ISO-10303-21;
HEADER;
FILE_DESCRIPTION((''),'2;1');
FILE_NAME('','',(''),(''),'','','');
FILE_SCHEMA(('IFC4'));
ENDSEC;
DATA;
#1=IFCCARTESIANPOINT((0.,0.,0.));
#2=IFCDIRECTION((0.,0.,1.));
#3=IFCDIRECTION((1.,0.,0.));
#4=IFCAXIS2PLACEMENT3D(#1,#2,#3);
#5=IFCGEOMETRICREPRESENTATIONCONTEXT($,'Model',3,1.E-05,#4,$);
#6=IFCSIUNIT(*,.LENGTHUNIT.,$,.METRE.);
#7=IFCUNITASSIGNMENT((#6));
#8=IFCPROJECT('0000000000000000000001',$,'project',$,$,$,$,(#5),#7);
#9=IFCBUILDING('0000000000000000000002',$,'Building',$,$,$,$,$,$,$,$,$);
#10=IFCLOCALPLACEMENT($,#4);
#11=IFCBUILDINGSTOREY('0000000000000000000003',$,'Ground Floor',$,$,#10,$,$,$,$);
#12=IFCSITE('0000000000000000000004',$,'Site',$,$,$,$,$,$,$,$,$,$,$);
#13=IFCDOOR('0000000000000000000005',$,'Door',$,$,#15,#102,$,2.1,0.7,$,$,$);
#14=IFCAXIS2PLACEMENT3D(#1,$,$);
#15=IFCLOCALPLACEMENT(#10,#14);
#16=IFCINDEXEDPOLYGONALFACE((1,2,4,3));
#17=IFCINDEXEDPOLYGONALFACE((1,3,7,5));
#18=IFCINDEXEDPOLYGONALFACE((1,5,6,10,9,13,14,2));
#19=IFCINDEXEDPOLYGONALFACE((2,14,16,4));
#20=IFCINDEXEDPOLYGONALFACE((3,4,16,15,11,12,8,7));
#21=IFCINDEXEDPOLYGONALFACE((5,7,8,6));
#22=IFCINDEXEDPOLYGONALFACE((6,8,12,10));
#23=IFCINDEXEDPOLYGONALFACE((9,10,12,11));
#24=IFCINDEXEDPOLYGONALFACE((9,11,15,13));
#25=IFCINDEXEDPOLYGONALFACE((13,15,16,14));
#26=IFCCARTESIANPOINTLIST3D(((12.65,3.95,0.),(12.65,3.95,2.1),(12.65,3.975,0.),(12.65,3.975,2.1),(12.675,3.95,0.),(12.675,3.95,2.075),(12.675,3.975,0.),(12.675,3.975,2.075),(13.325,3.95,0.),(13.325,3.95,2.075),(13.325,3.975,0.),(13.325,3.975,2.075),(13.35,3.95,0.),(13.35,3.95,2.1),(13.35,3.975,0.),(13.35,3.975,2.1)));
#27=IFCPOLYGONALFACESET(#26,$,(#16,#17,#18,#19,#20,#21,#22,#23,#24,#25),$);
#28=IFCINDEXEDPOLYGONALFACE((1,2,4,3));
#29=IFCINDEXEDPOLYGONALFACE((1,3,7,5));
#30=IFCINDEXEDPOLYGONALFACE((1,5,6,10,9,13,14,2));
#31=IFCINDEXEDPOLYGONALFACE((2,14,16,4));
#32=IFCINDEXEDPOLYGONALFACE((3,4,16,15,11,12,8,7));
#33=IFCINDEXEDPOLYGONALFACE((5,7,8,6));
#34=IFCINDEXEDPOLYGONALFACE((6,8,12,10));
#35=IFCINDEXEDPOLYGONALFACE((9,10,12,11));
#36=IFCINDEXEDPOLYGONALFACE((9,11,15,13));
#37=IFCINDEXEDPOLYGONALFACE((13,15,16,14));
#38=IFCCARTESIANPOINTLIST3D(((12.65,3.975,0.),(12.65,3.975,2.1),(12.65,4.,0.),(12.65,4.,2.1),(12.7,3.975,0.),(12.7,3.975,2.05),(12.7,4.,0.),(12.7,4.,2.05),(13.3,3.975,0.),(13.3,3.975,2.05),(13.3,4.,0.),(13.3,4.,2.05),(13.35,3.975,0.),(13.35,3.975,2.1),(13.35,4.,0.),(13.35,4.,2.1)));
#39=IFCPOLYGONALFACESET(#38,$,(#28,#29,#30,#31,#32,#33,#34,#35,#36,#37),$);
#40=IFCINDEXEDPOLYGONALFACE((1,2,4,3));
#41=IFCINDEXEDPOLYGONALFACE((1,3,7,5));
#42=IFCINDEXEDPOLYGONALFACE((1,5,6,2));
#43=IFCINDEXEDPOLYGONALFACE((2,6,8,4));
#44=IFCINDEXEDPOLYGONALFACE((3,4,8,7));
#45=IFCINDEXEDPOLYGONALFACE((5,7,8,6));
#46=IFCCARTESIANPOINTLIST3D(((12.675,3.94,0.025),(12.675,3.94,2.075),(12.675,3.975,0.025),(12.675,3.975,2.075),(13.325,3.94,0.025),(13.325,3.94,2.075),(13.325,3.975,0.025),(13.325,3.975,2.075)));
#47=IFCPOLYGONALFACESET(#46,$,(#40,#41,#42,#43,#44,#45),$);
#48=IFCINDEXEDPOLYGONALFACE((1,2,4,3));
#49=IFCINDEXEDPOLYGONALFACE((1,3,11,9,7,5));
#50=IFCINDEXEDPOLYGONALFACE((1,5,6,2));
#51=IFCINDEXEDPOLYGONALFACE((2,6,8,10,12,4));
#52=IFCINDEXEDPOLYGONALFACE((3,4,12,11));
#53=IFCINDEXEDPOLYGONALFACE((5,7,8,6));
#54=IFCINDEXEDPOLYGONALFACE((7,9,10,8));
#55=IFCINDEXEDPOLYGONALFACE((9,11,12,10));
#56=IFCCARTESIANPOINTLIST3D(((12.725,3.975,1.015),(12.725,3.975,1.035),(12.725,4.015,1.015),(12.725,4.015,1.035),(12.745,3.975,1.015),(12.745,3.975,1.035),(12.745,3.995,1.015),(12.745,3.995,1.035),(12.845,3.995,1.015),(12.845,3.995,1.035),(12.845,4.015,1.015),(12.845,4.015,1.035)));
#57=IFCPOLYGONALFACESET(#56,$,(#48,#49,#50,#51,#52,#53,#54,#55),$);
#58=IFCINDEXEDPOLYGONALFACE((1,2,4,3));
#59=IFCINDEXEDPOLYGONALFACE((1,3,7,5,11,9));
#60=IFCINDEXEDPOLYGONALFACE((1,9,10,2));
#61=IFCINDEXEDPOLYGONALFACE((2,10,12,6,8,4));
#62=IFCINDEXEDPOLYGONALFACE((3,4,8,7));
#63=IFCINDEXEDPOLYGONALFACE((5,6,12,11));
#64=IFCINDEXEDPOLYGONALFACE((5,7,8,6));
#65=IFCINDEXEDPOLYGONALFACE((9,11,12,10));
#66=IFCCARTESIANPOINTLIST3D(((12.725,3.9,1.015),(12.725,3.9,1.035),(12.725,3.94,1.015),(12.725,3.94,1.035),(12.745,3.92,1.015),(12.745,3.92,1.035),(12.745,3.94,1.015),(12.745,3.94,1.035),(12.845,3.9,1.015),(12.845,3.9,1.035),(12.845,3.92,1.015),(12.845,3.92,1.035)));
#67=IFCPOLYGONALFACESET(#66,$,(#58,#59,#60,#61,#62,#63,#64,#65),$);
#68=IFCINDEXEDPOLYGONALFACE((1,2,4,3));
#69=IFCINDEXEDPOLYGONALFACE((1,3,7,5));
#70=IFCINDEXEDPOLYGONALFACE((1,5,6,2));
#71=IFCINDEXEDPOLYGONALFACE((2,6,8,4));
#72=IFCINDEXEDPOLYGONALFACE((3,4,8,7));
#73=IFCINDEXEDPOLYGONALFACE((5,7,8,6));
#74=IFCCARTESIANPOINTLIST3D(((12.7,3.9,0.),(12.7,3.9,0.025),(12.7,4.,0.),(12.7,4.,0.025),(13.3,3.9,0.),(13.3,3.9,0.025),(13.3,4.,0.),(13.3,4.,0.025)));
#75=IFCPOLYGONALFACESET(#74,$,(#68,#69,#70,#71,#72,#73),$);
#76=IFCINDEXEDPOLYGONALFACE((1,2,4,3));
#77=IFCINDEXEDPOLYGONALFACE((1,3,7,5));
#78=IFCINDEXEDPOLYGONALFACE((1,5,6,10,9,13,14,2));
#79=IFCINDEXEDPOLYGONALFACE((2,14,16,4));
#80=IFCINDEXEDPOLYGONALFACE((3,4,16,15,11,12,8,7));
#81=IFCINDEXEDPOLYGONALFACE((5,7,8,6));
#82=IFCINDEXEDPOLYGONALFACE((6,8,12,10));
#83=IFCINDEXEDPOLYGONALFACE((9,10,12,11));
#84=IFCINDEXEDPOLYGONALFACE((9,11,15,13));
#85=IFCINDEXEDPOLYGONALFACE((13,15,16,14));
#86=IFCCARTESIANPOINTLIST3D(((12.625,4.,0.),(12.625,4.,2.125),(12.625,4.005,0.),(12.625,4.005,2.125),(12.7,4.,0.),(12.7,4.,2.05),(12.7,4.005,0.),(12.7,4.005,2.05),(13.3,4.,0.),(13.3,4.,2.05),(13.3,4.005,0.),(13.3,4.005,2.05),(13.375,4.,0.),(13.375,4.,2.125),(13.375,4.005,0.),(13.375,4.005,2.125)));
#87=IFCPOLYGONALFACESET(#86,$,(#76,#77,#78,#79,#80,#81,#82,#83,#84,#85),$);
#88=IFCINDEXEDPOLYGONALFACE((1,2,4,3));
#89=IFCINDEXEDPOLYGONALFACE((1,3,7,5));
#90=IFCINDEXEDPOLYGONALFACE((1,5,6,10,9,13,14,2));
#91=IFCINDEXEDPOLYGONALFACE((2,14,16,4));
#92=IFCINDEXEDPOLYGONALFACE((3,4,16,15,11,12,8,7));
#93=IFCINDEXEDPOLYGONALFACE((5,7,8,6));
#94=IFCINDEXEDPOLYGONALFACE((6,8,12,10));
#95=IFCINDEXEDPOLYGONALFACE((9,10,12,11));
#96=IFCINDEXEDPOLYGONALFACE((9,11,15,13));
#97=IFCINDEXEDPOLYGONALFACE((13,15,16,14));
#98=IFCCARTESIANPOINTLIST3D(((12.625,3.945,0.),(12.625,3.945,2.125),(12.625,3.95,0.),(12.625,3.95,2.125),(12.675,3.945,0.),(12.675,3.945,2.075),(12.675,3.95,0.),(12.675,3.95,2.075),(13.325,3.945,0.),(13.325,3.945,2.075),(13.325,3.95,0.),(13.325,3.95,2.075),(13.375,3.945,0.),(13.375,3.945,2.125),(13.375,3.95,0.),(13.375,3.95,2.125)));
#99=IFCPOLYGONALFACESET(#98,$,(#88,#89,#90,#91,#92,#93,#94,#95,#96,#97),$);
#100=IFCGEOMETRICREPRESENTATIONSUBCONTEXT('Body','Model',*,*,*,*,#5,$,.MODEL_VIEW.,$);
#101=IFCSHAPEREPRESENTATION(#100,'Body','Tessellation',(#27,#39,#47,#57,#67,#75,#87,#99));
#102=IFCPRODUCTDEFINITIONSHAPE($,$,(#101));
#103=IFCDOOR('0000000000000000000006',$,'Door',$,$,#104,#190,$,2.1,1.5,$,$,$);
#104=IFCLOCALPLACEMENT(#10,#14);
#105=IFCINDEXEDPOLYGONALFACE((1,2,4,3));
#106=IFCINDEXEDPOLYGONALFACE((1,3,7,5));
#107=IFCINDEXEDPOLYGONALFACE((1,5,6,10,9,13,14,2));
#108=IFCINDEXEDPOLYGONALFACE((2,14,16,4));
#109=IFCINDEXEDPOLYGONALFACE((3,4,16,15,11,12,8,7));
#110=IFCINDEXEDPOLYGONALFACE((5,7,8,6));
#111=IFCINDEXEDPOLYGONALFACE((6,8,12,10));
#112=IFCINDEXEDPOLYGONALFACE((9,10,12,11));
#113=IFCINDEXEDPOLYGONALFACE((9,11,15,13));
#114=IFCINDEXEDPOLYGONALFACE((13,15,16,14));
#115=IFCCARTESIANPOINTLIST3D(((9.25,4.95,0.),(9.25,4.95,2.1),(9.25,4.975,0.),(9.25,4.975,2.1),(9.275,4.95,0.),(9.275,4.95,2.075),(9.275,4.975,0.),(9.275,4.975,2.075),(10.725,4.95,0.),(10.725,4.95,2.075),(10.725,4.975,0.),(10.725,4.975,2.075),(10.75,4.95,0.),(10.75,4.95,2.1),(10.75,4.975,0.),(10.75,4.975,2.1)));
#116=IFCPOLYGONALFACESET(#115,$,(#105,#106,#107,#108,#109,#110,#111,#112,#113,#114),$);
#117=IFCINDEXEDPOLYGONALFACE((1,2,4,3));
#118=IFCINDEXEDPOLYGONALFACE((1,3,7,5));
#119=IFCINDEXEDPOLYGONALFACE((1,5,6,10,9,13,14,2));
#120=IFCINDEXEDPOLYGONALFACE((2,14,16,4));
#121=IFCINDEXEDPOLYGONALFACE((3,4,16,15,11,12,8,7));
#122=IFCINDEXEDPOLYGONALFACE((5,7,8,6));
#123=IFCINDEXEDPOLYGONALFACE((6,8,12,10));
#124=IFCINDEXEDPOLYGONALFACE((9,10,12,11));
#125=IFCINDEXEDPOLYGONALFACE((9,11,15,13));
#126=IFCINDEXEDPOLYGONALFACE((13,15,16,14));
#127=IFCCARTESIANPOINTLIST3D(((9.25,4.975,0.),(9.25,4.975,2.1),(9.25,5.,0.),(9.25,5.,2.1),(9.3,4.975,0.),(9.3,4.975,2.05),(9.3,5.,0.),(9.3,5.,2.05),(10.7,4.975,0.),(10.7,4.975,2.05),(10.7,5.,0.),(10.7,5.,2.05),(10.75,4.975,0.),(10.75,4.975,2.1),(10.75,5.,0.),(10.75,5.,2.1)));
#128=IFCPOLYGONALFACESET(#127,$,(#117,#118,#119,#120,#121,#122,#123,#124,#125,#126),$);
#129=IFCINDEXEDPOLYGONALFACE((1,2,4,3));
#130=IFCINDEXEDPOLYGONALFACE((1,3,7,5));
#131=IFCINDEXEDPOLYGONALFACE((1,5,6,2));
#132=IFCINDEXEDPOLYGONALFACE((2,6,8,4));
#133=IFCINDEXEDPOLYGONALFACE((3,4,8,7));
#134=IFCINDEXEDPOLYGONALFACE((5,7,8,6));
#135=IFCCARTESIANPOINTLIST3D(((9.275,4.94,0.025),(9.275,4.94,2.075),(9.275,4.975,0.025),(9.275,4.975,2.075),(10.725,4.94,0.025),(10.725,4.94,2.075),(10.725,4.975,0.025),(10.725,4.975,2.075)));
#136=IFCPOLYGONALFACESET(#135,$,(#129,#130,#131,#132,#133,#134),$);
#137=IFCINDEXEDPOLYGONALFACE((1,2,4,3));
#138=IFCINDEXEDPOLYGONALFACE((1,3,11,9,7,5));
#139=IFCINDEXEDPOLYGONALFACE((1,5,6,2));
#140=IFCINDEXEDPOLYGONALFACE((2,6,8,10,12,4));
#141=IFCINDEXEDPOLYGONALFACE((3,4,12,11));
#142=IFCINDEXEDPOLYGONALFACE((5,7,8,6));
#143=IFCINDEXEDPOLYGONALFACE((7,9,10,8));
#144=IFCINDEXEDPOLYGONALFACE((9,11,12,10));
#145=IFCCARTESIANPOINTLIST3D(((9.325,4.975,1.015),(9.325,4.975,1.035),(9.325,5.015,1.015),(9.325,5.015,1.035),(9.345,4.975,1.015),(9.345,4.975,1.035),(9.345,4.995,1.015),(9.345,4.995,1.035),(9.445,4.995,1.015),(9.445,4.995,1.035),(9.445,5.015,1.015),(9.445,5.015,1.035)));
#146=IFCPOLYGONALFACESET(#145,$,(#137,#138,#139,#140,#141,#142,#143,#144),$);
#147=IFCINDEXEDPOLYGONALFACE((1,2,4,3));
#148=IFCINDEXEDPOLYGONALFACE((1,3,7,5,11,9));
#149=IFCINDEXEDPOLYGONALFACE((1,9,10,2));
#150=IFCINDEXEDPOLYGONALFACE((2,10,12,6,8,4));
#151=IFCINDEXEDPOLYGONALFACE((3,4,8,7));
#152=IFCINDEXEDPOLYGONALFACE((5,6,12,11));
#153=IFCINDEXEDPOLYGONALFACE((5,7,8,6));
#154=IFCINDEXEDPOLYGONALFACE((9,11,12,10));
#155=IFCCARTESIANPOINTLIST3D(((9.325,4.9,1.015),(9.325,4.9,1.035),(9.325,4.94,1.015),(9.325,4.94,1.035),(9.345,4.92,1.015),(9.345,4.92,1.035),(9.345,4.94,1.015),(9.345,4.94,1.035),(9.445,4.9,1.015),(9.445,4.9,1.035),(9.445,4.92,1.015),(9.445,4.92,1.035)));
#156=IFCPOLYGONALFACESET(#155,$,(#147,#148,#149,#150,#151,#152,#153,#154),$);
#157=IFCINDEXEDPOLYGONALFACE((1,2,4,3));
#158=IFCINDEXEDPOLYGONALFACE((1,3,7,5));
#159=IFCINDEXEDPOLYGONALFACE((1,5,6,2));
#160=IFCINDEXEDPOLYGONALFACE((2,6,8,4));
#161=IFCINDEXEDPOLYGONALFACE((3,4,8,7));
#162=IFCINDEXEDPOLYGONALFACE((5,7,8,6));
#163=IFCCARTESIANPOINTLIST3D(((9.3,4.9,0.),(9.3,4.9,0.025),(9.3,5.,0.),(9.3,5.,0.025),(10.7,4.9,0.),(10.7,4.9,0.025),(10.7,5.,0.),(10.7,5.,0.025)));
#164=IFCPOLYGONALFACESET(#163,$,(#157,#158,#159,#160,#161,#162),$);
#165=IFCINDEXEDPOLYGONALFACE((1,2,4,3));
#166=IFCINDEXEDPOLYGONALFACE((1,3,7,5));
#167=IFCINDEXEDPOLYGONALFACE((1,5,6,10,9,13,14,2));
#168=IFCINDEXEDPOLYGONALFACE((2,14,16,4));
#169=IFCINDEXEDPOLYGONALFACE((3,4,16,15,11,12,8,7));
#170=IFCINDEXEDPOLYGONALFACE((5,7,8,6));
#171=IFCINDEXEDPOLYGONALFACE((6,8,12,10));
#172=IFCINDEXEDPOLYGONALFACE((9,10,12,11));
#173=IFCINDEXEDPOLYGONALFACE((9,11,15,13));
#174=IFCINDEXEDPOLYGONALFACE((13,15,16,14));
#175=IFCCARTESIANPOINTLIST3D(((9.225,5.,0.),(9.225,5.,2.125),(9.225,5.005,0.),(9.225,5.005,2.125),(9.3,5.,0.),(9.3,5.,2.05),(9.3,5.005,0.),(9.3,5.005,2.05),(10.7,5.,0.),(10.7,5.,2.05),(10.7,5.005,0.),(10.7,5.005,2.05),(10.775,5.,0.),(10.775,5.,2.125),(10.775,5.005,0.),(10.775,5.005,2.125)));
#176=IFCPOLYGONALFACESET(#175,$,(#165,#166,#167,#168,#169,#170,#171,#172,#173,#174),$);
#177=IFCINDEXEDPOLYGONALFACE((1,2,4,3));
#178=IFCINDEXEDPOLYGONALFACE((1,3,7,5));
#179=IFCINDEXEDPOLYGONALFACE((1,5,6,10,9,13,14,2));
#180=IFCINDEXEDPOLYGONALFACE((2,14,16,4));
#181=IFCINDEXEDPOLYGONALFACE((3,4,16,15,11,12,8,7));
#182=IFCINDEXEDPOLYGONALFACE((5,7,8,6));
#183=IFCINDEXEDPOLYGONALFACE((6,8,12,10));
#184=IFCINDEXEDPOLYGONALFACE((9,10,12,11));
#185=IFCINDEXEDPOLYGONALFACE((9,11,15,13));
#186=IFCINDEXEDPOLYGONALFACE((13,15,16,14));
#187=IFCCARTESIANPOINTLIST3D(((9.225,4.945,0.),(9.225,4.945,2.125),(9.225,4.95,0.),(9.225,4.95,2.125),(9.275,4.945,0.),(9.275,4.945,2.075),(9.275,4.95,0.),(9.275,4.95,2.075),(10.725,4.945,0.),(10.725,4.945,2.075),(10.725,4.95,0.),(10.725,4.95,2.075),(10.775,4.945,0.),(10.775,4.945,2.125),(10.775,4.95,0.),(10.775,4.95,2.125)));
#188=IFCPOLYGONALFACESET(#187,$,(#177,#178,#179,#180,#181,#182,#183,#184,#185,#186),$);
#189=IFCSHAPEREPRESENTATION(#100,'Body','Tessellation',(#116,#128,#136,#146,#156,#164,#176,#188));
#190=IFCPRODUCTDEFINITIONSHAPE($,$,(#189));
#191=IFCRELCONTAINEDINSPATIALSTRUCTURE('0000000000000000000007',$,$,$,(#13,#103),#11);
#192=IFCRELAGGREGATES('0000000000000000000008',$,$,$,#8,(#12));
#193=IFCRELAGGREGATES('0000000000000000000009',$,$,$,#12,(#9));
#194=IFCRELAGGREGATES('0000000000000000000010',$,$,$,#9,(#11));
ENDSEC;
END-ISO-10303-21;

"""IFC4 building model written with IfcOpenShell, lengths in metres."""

from ifc_helpers import new_model, si_unit, frame, origin_with_axes, place, context, subcontext, project, spatial, line, indexed_curve, outline, extrude, element, save


model = new_model("IFC4")

# Units and contexts
model_context = context("Model", 3, precision=1e-05, world=origin_with_axes())
body_context = subcontext(model_context, "Body", "Model", "MODEL_VIEW")
ifc_project = project(units=[si_unit("LENGTHUNIT", "METRE")], contexts=[model_context])

# Site, building, storey
site = spatial("IfcSite", under=ifc_project, Name="Site")
building = spatial("IfcBuilding", under=site, Name="Building")
storey_placement = place(None, origin_with_axes())
storey = spatial("IfcBuildingStorey", under=building, at=storey_placement, Name="Ground Floor")

# Doors
door_1_placement = place(storey_placement, frame((13.35, 4.0, 0.0), z_axis=(0.0, 0.0, 1.0), x_axis=(-1.0, 0.0, 0.0)))
element("IfcDoor", 1, at=door_1_placement, inside=storey, Name="Door", OverallHeight=2.1, OverallWidth=0.7, context=body_context, shape_type="SweptSolid", body=[
    extrude(outline(indexed_curve([(0.0, 0.0), (0.0, 2.1), (0.7, 2.1), (0.7, 0.0), (0.675, 0.0), (0.675, 2.075), (0.025, 2.075), (0.025, 0.0)], segments=[line(1, 2, 3, 4, 5, 6, 7, 8, 1)])), frame((0.0, 0.025, 0.0), z_axis=(0.0, -1.0, 0.0), x_axis=(1.0, 0.0, 0.0)), (0.0, 0.0, -1.0), 0.025),
    extrude(outline(indexed_curve([(0.0, 0.0), (0.0, 2.1), (0.7, 2.1), (0.7, 0.0), (0.65, 0.0), (0.65, 2.05), (0.05, 2.05), (0.05, 0.0)], segments=[line(1, 2, 3, 4, 5, 6, 7, 8, 1)])), frame((0.0, 0.0, 0.0), z_axis=(0.0, -1.0, 0.0), x_axis=(1.0, 0.0, 0.0)), (0.0, 0.0, -1.0), 0.025),
    extrude(outline(indexed_curve([(0.0, 0.0), (0.65, 0.0), (0.65, 0.035), (0.0, 0.035)], segments=[line(1, 2, 3, 4, 1)])), frame((0.025, 0.025, 0.025), z_axis=(0.0, 0.0, 1.0), x_axis=(1.0, 0.0, 0.0)), (0.0, 0.0, 1.0), 2.05),
    extrude(outline(indexed_curve([(0.0, 0.0), (0.0, -0.04), (-0.12, -0.04), (-0.12, -0.02), (-0.02, -0.02), (-0.02, 0.0)], segments=[line(1, 2, 3, 4, 5, 6, 1)])), frame((0.625, 0.025, 1.015), z_axis=(0.0, 0.0, 1.0), x_axis=(1.0, 0.0, 0.0)), (0.0, 0.0, 1.0), 0.02),
    extrude(outline(indexed_curve([(0.0, 0.0), (0.0, 0.04), (-0.12, 0.04), (-0.12, 0.02), (-0.02, 0.02), (-0.02, 0.0)], segments=[line(1, 2, 3, 4, 5, 6, 1)])), frame((0.625, 0.06, 1.015), z_axis=(0.0, 0.0, 1.0), x_axis=(1.0, 0.0, 0.0)), (0.0, 0.0, 1.0), 0.02),
    extrude(outline(indexed_curve([(0.0, 0.0), (0.6, 0.0), (0.6, 0.1), (0.0, 0.1)], segments=[line(1, 2, 3, 4, 1)])), frame((0.05, 0.0, 0.0), z_axis=(0.0, 0.0, 1.0), x_axis=(1.0, 0.0, 0.0)), (0.0, 0.0, 1.0), 0.025),
    extrude(outline(indexed_curve([(0.0, 0.0), (0.0, 2.125), (0.75, 2.125), (0.75, 0.0), (0.675, 0.0), (0.675, 2.05), (0.075, 2.05), (0.075, 0.0)], segments=[line(1, 2, 3, 4, 5, 6, 7, 8, 1)])), frame((-0.025, -0.005, 0.0), z_axis=(0.0, -1.0, 0.0), x_axis=(1.0, 0.0, 0.0)), (0.0, 0.0, -1.0), 0.005),
    extrude(outline(indexed_curve([(0.0, 0.0), (0.0, 2.125), (0.75, 2.125), (0.75, 0.0), (0.7, 0.0), (0.7, 2.075), (0.05, 2.075), (0.05, 0.0)], segments=[line(1, 2, 3, 4, 5, 6, 7, 8, 1)])), frame((-0.025, 0.05, 0.0), z_axis=(0.0, -1.0, 0.0), x_axis=(1.0, 0.0, 0.0)), (0.0, 0.0, -1.0), 0.005),
])
door_2_placement = place(storey_placement, frame((10.75, 5.0, 0.0), z_axis=(0.0, 0.0, 1.0), x_axis=(-1.0, 0.0, 0.0)))
element("IfcDoor", 2, at=door_2_placement, inside=storey, Name="Door", OverallHeight=2.1, OverallWidth=1.5, context=body_context, shape_type="SweptSolid", body=[
    extrude(outline(indexed_curve([(0.0, 0.0), (0.0, 2.1), (1.5, 2.1), (1.5, 0.0), (1.475, 0.0), (1.475, 2.075), (0.025, 2.075), (0.025, 0.0)], segments=[line(1, 2, 3, 4, 5, 6, 7, 8, 1)])), frame((0.0, 0.025, 0.0), z_axis=(0.0, -1.0, 0.0), x_axis=(1.0, 0.0, 0.0)), (0.0, 0.0, -1.0), 0.025),
    extrude(outline(indexed_curve([(0.0, 0.0), (0.0, 2.1), (1.5, 2.1), (1.5, 0.0), (1.45, 0.0), (1.45, 2.05), (0.05, 2.05), (0.05, 0.0)], segments=[line(1, 2, 3, 4, 5, 6, 7, 8, 1)])), frame((0.0, 0.0, 0.0), z_axis=(0.0, -1.0, 0.0), x_axis=(1.0, 0.0, 0.0)), (0.0, 0.0, -1.0), 0.025),
    extrude(outline(indexed_curve([(0.0, 0.0), (1.45, 0.0), (1.45, 0.035), (0.0, 0.035)], segments=[line(1, 2, 3, 4, 1)])), frame((0.025, 0.025, 0.025), z_axis=(0.0, 0.0, 1.0), x_axis=(1.0, 0.0, 0.0)), (0.0, 0.0, 1.0), 2.05),
    extrude(outline(indexed_curve([(0.0, 0.0), (0.0, -0.04), (-0.12, -0.04), (-0.12, -0.02), (-0.02, -0.02), (-0.02, 0.0)], segments=[line(1, 2, 3, 4, 5, 6, 1)])), frame((1.425, 0.025, 1.015), z_axis=(0.0, 0.0, 1.0), x_axis=(1.0, 0.0, 0.0)), (0.0, 0.0, 1.0), 0.02),
    extrude(outline(indexed_curve([(0.0, 0.0), (0.0, 0.04), (-0.12, 0.04), (-0.12, 0.02), (-0.02, 0.02), (-0.02, 0.0)], segments=[line(1, 2, 3, 4, 5, 6, 1)])), frame((1.425, 0.06, 1.015), z_axis=(0.0, 0.0, 1.0), x_axis=(1.0, 0.0, 0.0)), (0.0, 0.0, 1.0), 0.02),
    extrude(outline(indexed_curve([(0.0, 0.0), (1.4, 0.0), (1.4, 0.1), (0.0, 0.1)], segments=[line(1, 2, 3, 4, 1)])), frame((0.05, 0.0, 0.0), z_axis=(0.0, 0.0, 1.0), x_axis=(1.0, 0.0, 0.0)), (0.0, 0.0, 1.0), 0.025),
    extrude(outline(indexed_curve([(0.0, 0.0), (0.0, 2.125), (1.55, 2.125), (1.55, 0.0), (1.475, 0.0), (1.475, 2.05), (0.075, 2.05), (0.075, 0.0)], segments=[line(1, 2, 3, 4, 5, 6, 7, 8, 1)])), frame((-0.025, -0.005, 0.0), z_axis=(0.0, -1.0, 0.0), x_axis=(1.0, 0.0, 0.0)), (0.0, 0.0, -1.0), 0.005),
    extrude(outline(indexed_curve([(0.0, 0.0), (0.0, 2.125), (1.55, 2.125), (1.55, 0.0), (1.5, 0.0), (1.5, 2.075), (0.05, 2.075), (0.05, 0.0)], segments=[line(1, 2, 3, 4, 5, 6, 7, 8, 1)])), frame((-0.025, 0.05, 0.0), z_axis=(0.0, -1.0, 0.0), x_axis=(1.0, 0.0, 0.0)), (0.0, 0.0, -1.0), 0.005),
])

save(model, "model.ifc")
